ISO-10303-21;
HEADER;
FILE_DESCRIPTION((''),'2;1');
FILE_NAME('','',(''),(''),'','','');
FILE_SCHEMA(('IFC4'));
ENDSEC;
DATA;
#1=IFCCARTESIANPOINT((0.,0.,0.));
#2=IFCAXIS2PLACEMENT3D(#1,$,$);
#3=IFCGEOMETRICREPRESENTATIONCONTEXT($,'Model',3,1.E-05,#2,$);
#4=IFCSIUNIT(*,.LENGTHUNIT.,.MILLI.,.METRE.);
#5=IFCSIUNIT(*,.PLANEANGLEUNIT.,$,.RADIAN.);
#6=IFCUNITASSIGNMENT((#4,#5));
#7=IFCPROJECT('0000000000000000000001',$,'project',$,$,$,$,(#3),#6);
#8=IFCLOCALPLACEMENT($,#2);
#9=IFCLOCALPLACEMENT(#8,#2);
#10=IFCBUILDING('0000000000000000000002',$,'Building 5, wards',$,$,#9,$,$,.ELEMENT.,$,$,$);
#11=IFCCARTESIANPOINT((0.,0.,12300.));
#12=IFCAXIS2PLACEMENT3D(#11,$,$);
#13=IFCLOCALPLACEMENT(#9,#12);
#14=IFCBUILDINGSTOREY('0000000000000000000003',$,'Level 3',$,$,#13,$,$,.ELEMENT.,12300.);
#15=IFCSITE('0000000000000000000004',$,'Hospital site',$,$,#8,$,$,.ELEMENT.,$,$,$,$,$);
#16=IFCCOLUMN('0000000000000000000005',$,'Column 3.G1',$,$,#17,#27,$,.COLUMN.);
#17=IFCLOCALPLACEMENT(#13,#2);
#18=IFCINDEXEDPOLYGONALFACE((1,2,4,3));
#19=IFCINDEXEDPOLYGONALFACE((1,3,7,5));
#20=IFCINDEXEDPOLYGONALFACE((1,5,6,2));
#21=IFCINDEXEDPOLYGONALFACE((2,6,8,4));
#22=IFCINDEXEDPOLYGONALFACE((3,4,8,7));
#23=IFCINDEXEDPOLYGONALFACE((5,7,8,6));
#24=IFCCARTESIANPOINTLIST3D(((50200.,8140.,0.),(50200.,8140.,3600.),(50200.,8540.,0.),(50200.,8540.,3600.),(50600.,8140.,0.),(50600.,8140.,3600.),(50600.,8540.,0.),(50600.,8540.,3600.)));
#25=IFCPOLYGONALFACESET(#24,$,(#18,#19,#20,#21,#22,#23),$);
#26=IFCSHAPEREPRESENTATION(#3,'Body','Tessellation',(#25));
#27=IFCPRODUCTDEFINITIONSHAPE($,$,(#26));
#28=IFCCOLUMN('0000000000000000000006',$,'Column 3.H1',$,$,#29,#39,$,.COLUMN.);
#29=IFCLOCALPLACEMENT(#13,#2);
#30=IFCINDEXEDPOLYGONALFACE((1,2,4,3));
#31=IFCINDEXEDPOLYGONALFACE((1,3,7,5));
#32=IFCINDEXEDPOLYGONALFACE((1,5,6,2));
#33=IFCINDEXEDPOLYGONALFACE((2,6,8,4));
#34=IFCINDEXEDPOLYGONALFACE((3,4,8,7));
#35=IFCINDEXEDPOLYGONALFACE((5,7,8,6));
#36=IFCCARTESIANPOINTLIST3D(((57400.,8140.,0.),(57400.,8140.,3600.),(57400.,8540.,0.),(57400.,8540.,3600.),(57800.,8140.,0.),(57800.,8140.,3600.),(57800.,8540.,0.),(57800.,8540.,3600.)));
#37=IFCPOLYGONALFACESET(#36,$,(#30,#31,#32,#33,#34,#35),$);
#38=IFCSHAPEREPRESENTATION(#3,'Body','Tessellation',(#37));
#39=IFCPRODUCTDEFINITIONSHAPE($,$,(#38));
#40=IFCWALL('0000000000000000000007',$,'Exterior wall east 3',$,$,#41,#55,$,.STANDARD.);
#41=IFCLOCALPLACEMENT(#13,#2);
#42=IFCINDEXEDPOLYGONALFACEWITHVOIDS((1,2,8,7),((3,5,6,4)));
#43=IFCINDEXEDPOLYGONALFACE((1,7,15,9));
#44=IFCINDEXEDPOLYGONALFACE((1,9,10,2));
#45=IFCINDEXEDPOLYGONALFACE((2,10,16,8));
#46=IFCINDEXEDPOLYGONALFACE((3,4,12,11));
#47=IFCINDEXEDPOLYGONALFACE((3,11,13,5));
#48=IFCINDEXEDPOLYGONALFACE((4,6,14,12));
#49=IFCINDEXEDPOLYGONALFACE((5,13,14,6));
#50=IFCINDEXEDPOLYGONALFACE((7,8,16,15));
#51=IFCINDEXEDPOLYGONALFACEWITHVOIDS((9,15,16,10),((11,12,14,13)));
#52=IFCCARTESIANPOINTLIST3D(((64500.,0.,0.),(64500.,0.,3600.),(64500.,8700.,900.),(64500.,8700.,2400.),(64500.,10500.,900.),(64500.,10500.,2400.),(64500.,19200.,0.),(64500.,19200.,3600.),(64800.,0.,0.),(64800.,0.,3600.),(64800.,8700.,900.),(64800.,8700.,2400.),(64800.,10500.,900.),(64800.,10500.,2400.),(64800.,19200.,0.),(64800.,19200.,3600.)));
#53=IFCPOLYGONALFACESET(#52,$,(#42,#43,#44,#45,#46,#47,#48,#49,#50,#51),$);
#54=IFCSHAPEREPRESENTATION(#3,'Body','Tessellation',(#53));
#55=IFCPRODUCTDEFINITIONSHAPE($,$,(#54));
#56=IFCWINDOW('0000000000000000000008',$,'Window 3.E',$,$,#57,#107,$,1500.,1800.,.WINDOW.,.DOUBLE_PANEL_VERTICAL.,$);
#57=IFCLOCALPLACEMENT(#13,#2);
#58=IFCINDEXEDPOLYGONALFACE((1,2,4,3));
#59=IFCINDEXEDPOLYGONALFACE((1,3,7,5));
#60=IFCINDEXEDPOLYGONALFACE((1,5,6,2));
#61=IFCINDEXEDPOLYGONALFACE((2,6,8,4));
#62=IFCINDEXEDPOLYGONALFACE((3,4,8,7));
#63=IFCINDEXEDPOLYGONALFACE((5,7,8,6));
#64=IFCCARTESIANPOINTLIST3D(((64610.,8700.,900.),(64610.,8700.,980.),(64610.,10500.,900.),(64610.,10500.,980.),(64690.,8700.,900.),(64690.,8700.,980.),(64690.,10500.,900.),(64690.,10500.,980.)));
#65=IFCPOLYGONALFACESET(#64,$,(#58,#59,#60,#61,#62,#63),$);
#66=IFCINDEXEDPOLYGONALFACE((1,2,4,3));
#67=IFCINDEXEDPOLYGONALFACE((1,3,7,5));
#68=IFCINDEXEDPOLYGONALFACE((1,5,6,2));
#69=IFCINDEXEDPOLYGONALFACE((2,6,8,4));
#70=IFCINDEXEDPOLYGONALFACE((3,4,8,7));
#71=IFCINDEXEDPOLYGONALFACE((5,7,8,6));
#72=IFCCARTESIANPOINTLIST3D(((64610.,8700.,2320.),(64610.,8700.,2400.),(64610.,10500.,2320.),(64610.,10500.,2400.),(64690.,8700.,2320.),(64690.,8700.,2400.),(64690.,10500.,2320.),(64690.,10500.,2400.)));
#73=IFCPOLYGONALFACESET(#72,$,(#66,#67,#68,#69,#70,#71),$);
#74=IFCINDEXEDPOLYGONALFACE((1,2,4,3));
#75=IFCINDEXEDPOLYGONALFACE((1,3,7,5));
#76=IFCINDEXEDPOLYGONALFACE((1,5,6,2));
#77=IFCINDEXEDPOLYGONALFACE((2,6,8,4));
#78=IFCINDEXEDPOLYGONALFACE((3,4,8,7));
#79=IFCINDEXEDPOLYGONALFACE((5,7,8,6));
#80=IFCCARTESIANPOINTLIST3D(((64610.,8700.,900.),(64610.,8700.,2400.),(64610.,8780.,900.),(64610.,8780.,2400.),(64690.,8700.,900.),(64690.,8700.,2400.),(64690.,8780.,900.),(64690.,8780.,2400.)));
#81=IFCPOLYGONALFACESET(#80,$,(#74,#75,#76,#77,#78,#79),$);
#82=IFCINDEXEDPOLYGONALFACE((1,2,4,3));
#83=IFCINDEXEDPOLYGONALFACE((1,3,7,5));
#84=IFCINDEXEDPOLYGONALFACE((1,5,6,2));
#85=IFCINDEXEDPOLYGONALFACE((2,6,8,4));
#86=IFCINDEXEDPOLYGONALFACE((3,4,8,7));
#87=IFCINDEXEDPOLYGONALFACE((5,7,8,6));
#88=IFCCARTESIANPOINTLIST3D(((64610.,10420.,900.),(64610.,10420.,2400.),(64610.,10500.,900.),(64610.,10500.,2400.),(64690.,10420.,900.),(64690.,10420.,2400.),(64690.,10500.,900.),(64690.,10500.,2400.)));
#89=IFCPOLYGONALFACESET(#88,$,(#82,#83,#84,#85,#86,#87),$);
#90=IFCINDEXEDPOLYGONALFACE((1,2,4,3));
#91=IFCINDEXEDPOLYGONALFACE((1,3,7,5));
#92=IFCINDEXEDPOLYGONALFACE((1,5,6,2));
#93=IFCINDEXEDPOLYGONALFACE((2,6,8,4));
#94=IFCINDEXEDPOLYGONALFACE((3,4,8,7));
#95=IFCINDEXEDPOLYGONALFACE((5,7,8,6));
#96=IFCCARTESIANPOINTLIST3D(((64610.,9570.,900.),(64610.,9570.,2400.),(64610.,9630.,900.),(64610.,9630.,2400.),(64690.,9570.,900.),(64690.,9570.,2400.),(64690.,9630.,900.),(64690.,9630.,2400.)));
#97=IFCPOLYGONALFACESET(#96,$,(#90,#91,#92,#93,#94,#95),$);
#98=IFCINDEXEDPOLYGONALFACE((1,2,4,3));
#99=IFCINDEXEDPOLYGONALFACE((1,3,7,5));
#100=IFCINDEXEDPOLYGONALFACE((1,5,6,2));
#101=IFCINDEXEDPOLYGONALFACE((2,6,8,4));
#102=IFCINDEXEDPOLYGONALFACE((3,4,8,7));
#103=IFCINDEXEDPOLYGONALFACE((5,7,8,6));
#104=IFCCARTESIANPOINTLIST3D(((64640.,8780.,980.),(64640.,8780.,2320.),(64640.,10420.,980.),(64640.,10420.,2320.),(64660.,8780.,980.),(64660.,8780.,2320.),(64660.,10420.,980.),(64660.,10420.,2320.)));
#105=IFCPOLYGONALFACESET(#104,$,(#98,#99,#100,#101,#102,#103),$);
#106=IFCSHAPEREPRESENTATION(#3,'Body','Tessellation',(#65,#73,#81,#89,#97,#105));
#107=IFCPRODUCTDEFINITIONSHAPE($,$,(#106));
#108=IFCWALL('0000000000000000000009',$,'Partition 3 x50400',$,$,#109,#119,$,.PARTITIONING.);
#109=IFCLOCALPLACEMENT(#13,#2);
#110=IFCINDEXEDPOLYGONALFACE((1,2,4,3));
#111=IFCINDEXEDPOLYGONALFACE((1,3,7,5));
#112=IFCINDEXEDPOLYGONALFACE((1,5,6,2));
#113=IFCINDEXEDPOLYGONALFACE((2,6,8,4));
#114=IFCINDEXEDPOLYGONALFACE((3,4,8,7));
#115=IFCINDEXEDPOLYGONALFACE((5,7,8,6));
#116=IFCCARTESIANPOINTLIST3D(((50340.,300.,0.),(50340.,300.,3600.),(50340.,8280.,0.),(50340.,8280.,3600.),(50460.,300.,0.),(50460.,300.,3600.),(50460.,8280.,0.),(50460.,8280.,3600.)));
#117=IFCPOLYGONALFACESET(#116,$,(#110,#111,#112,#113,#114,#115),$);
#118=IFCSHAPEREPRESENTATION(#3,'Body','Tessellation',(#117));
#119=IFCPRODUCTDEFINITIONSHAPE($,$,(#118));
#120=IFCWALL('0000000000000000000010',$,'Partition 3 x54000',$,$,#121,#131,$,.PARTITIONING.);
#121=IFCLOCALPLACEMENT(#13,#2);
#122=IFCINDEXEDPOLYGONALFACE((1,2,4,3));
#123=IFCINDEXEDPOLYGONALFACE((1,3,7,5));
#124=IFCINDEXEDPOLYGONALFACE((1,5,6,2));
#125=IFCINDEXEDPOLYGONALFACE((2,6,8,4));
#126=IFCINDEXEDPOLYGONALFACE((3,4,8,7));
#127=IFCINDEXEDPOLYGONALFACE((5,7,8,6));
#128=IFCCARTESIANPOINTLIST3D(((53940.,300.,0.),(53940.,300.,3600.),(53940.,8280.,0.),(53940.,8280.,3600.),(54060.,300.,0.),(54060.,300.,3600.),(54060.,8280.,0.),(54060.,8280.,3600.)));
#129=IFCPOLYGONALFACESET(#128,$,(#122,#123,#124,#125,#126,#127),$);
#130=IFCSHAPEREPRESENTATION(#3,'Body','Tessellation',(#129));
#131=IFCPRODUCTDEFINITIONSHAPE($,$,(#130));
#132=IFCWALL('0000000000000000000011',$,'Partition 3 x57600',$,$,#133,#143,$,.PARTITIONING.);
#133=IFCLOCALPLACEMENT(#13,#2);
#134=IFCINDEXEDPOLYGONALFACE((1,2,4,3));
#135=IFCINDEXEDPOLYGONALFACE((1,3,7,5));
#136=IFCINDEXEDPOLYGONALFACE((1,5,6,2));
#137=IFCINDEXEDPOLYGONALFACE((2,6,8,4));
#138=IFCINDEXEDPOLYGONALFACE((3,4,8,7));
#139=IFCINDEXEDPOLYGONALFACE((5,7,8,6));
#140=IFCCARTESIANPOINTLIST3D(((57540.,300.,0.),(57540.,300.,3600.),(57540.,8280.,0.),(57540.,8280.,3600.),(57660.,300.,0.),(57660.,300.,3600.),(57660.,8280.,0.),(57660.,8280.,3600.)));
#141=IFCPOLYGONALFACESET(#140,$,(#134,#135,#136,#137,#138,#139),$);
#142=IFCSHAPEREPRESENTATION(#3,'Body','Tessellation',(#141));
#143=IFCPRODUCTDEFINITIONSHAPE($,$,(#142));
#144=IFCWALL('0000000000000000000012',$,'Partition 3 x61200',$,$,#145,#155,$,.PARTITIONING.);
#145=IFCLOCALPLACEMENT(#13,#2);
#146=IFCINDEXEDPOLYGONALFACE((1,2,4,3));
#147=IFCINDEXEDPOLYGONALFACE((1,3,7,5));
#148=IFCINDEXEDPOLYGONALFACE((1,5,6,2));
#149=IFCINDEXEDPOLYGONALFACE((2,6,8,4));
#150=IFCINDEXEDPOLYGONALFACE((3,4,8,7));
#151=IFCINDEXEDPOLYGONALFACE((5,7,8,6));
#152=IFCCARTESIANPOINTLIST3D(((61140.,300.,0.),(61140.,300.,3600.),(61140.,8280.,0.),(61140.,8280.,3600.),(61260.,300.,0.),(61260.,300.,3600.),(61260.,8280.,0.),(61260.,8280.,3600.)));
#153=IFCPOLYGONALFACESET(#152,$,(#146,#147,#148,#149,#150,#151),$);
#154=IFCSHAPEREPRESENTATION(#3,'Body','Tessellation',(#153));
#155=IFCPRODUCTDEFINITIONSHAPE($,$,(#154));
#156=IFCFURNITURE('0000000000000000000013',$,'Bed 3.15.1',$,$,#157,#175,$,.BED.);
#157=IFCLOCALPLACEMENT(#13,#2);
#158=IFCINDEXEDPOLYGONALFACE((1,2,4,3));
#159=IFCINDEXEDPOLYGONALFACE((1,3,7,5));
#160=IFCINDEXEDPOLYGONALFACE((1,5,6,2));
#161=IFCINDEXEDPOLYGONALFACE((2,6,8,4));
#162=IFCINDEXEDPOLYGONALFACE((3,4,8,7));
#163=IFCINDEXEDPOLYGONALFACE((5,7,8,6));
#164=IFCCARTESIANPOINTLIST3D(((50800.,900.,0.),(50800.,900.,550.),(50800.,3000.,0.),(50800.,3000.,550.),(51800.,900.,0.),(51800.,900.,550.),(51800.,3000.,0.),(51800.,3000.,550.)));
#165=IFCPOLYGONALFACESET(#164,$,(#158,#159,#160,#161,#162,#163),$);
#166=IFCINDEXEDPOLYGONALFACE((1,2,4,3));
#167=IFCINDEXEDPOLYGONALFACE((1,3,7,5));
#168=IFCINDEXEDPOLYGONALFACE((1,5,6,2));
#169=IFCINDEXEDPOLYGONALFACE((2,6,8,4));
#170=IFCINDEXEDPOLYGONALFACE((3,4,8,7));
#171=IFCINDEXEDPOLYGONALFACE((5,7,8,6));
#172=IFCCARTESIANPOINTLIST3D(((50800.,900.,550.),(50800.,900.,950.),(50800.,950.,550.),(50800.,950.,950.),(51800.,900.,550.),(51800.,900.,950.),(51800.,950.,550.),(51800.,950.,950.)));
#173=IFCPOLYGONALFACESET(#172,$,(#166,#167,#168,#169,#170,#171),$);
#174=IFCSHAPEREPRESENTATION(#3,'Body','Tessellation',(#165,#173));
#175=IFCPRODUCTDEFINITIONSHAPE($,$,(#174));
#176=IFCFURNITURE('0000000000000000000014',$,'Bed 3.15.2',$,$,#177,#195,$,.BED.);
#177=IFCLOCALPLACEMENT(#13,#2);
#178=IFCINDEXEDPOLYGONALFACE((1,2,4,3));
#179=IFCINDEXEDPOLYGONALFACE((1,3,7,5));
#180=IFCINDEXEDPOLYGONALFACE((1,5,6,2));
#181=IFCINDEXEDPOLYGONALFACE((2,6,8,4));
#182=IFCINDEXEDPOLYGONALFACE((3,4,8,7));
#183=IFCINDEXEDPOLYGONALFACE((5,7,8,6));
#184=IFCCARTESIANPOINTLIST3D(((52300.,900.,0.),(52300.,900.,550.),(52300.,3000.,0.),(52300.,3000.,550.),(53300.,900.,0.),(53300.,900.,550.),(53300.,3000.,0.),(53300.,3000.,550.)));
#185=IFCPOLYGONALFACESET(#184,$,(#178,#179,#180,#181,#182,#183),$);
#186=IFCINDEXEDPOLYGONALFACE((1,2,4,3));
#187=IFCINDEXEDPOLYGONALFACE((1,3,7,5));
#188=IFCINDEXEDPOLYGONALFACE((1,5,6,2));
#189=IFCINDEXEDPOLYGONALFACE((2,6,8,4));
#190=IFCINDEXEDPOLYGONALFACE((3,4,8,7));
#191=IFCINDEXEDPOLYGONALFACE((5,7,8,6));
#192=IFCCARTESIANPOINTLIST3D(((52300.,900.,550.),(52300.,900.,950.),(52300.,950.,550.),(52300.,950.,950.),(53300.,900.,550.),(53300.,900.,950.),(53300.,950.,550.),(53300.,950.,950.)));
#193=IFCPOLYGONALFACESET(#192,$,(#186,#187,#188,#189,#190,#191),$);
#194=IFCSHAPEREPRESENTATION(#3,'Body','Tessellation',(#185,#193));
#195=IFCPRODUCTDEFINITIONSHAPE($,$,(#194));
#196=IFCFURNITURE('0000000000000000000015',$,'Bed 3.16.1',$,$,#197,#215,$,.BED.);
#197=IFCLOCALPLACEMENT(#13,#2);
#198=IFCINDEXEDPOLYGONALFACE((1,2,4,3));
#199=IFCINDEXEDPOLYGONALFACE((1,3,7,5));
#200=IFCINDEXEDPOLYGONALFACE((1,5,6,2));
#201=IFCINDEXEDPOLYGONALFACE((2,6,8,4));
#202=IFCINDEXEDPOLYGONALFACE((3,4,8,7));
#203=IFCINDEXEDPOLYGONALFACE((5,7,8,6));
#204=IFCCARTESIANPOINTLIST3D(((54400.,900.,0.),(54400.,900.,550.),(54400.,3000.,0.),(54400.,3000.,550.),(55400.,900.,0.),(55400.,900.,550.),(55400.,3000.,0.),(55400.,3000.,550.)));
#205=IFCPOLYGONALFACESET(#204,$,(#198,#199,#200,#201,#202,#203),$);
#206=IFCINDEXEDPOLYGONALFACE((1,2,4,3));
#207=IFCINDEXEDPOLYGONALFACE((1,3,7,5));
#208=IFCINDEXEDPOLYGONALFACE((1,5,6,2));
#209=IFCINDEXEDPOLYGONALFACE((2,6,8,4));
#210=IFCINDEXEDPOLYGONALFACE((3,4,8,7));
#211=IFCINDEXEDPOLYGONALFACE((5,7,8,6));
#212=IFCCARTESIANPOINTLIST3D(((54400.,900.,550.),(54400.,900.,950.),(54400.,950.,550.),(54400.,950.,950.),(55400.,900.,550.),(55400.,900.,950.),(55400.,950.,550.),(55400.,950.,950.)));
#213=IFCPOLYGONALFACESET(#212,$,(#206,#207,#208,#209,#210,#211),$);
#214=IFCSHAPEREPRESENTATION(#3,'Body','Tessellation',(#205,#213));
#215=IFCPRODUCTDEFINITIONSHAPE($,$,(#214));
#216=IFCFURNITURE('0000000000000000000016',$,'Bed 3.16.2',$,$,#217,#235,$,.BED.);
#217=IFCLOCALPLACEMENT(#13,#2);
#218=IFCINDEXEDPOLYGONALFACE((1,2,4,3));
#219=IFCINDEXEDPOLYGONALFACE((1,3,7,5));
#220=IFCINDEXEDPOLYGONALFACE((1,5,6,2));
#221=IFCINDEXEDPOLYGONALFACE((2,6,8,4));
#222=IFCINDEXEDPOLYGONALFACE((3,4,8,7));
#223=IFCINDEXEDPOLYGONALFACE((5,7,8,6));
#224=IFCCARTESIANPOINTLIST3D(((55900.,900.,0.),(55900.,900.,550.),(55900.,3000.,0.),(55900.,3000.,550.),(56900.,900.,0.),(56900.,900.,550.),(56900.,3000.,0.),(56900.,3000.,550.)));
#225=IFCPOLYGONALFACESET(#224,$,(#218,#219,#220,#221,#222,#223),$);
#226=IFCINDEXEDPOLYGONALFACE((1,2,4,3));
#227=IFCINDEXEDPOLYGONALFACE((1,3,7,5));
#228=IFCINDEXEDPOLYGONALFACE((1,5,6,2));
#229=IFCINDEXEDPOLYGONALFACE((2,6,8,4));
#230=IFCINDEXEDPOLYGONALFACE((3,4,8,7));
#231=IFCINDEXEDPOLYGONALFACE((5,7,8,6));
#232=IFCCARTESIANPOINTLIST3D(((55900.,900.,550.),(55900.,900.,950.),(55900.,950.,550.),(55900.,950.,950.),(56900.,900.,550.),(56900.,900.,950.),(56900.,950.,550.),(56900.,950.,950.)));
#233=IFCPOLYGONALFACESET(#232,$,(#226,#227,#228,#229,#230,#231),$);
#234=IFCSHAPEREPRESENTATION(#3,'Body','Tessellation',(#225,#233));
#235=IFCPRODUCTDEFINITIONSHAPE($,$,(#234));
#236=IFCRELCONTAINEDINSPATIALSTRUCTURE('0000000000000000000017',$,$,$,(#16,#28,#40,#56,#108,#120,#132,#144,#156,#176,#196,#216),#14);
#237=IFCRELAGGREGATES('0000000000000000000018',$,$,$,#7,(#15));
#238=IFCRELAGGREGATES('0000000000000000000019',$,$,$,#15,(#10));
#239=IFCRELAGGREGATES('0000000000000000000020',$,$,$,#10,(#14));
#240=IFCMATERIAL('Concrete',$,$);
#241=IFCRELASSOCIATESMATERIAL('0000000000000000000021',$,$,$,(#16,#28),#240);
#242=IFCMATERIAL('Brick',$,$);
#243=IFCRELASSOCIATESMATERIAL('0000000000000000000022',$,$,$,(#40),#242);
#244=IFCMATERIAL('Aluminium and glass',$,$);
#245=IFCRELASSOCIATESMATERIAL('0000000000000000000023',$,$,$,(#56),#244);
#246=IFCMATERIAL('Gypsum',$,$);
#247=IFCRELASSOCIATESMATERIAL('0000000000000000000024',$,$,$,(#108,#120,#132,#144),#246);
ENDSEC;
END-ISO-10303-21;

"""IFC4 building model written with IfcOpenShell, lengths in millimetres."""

from ifc_helpers import new_model, si_unit, frame, frame_2d, origin, origin_2d, place, context, project, spatial, rectangle, extrude, material, element, fill, save


model = new_model("IFC4")

# Units and contexts
model_context = context("Model", 3, precision=1e-05, world=origin())
ifc_project = project(units=[si_unit("LENGTHUNIT", "METRE", prefix="MILLI"), si_unit("PLANEANGLEUNIT", "RADIAN")], contexts=[model_context])

# Site, building, storey
site_placement = place(None, origin())
site = spatial("IfcSite", under=ifc_project, at=site_placement, Name="Hospital site", CompositionType="ELEMENT")
building_placement = place(site_placement, origin())
building = spatial("IfcBuilding", under=site, at=building_placement, Name="Building 5, wards", CompositionType="ELEMENT")
storey_placement = place(building_placement, frame((0.0, 0.0, 12300.0)))
storey = spatial("IfcBuildingStorey", under=building, at=storey_placement, Name="Level 3", CompositionType="ELEMENT", Elevation=12300.0)

# Columns
ifc_material_1 = material(Name="Concrete")
for number, where, name in (
    (1, (50400.0, 8340.0, 0.0), "Column 3.G1"),
    (2, (57600.0, 8340.0, 0.0), "Column 3.H1"),
):
    element("IfcColumn", number, at=place(storey_placement, frame(where)), inside=storey, material=ifc_material_1, Name=name, PredefinedType="COLUMN", context=model_context, shape_type="SweptSolid", body=[
        extrude(rectangle(XDim=400.0, YDim=400.0, at=origin_2d()), origin(), (0.0, 0.0, 1.0), 3600.0),
    ])

# Wall, opening, window
ifc_material_2 = material(Name="Brick")
wall_placement = place(storey_placement, frame((64800.0, 0.0, 0.0), x_axis=(0.0, 1.0, 0.0)))
wall = element("IfcWall", 3, at=wall_placement, inside=storey, material=ifc_material_2, Name="Exterior wall east 3", PredefinedType="STANDARD", context=model_context, shape_type="SweptSolid", body=[
    extrude(rectangle(XDim=19200.0, YDim=300.0, at=frame_2d((9600.0, 150.0))), origin(), (0.0, 0.0, 1.0), 3600.0),
])
opening_placement = place(wall_placement, frame((8700.0, -50.0, 900.0)))
opening = element("IfcOpeningElement", 4, at=opening_placement, cuts=wall, PredefinedType="OPENING", context=model_context, shape_type="SweptSolid", body=[
    extrude(rectangle(XDim=1800.0, YDim=400.0, at=frame_2d((900.0, 200.0))), origin(), (0.0, 0.0, 1.0), 1500.0),
])
ifc_material_3 = material(Name="Aluminium and glass")
window_placement = place(opening_placement, frame((0.0, 160.0, 0.0)))
window = element("IfcWindow", 5, at=window_placement, inside=storey, material=ifc_material_3, Name="Window 3.E", OverallHeight=1500.0, OverallWidth=1800.0, PartitioningType="DOUBLE_PANEL_VERTICAL", PredefinedType="WINDOW", context=model_context, shape_type="SweptSolid", body=[
    extrude(rectangle(XDim=1800.0, YDim=80.0, at=frame_2d((900.0, 40.0))), origin(), (0.0, 0.0, 1.0), 80.0),
    extrude(rectangle(XDim=1800.0, YDim=80.0, at=frame_2d((900.0, 40.0))), frame((0.0, 0.0, 1420.0)), (0.0, 0.0, 1.0), 80.0),
    extrude(rectangle(XDim=80.0, YDim=80.0, at=frame_2d((40.0, 40.0))), origin(), (0.0, 0.0, 1.0), 1500.0),
    extrude(rectangle(XDim=80.0, YDim=80.0, at=frame_2d((1760.0, 40.0))), origin(), (0.0, 0.0, 1.0), 1500.0),
    extrude(rectangle(XDim=60.0, YDim=80.0, at=frame_2d((900.0, 40.0))), origin(), (0.0, 0.0, 1.0), 1500.0),
    extrude(rectangle(XDim=1640.0, YDim=20.0, at=frame_2d((900.0, 40.0))), frame((0.0, 0.0, 80.0)), (0.0, 0.0, 1.0), 1340.0),
])
fill(opening, window)

# Walls
ifc_material_4 = material(Name="Gypsum")
for number, where, x_axis, name in (
    (6, (50460.0, 300.0, 0.0), (0.0, 1.0, 0.0), "Partition 3 x50400"),
    (7, (54060.0, 300.0, 0.0), (0.0, 1.0, 0.0), "Partition 3 x54000"),
    (8, (57660.0, 300.0, 0.0), (0.0, 1.0, 0.0), "Partition 3 x57600"),
    (9, (61260.0, 300.0, 0.0), (0.0, 1.0, 0.0), "Partition 3 x61200"),
):
    element("IfcWall", number, at=place(storey_placement, frame(where, x_axis=x_axis)), inside=storey, material=ifc_material_4, Name=name, PredefinedType="PARTITIONING", context=model_context, shape_type="SweptSolid", body=[
        extrude(rectangle(XDim=7980.0, YDim=120.0, at=frame_2d((3990.0, 60.0))), origin(), (0.0, 0.0, 1.0), 3600.0),
    ])

# Furniture
for number, where, name in (
    (10, (50800.0, 900.0, 0.0), "Bed 3.15.1"),
    (11, (52300.0, 900.0, 0.0), "Bed 3.15.2"),
    (12, (54400.0, 900.0, 0.0), "Bed 3.16.1"),
    (13, (55900.0, 900.0, 0.0), "Bed 3.16.2"),
):
    element("IfcFurniture", number, at=place(storey_placement, frame(where)), inside=storey, Name=name, PredefinedType="BED", context=model_context, shape_type="SweptSolid", body=[
        extrude(rectangle(XDim=1000.0, YDim=2100.0, at=frame_2d((500.0, 1050.0))), origin(), (0.0, 0.0, 1.0), 550.0),
        extrude(rectangle(XDim=1000.0, YDim=50.0, at=frame_2d((500.0, 25.0))), frame((0.0, 0.0, 550.0)), (0.0, 0.0, 1.0), 400.0),
    ])

save(model, "model.ifc")
